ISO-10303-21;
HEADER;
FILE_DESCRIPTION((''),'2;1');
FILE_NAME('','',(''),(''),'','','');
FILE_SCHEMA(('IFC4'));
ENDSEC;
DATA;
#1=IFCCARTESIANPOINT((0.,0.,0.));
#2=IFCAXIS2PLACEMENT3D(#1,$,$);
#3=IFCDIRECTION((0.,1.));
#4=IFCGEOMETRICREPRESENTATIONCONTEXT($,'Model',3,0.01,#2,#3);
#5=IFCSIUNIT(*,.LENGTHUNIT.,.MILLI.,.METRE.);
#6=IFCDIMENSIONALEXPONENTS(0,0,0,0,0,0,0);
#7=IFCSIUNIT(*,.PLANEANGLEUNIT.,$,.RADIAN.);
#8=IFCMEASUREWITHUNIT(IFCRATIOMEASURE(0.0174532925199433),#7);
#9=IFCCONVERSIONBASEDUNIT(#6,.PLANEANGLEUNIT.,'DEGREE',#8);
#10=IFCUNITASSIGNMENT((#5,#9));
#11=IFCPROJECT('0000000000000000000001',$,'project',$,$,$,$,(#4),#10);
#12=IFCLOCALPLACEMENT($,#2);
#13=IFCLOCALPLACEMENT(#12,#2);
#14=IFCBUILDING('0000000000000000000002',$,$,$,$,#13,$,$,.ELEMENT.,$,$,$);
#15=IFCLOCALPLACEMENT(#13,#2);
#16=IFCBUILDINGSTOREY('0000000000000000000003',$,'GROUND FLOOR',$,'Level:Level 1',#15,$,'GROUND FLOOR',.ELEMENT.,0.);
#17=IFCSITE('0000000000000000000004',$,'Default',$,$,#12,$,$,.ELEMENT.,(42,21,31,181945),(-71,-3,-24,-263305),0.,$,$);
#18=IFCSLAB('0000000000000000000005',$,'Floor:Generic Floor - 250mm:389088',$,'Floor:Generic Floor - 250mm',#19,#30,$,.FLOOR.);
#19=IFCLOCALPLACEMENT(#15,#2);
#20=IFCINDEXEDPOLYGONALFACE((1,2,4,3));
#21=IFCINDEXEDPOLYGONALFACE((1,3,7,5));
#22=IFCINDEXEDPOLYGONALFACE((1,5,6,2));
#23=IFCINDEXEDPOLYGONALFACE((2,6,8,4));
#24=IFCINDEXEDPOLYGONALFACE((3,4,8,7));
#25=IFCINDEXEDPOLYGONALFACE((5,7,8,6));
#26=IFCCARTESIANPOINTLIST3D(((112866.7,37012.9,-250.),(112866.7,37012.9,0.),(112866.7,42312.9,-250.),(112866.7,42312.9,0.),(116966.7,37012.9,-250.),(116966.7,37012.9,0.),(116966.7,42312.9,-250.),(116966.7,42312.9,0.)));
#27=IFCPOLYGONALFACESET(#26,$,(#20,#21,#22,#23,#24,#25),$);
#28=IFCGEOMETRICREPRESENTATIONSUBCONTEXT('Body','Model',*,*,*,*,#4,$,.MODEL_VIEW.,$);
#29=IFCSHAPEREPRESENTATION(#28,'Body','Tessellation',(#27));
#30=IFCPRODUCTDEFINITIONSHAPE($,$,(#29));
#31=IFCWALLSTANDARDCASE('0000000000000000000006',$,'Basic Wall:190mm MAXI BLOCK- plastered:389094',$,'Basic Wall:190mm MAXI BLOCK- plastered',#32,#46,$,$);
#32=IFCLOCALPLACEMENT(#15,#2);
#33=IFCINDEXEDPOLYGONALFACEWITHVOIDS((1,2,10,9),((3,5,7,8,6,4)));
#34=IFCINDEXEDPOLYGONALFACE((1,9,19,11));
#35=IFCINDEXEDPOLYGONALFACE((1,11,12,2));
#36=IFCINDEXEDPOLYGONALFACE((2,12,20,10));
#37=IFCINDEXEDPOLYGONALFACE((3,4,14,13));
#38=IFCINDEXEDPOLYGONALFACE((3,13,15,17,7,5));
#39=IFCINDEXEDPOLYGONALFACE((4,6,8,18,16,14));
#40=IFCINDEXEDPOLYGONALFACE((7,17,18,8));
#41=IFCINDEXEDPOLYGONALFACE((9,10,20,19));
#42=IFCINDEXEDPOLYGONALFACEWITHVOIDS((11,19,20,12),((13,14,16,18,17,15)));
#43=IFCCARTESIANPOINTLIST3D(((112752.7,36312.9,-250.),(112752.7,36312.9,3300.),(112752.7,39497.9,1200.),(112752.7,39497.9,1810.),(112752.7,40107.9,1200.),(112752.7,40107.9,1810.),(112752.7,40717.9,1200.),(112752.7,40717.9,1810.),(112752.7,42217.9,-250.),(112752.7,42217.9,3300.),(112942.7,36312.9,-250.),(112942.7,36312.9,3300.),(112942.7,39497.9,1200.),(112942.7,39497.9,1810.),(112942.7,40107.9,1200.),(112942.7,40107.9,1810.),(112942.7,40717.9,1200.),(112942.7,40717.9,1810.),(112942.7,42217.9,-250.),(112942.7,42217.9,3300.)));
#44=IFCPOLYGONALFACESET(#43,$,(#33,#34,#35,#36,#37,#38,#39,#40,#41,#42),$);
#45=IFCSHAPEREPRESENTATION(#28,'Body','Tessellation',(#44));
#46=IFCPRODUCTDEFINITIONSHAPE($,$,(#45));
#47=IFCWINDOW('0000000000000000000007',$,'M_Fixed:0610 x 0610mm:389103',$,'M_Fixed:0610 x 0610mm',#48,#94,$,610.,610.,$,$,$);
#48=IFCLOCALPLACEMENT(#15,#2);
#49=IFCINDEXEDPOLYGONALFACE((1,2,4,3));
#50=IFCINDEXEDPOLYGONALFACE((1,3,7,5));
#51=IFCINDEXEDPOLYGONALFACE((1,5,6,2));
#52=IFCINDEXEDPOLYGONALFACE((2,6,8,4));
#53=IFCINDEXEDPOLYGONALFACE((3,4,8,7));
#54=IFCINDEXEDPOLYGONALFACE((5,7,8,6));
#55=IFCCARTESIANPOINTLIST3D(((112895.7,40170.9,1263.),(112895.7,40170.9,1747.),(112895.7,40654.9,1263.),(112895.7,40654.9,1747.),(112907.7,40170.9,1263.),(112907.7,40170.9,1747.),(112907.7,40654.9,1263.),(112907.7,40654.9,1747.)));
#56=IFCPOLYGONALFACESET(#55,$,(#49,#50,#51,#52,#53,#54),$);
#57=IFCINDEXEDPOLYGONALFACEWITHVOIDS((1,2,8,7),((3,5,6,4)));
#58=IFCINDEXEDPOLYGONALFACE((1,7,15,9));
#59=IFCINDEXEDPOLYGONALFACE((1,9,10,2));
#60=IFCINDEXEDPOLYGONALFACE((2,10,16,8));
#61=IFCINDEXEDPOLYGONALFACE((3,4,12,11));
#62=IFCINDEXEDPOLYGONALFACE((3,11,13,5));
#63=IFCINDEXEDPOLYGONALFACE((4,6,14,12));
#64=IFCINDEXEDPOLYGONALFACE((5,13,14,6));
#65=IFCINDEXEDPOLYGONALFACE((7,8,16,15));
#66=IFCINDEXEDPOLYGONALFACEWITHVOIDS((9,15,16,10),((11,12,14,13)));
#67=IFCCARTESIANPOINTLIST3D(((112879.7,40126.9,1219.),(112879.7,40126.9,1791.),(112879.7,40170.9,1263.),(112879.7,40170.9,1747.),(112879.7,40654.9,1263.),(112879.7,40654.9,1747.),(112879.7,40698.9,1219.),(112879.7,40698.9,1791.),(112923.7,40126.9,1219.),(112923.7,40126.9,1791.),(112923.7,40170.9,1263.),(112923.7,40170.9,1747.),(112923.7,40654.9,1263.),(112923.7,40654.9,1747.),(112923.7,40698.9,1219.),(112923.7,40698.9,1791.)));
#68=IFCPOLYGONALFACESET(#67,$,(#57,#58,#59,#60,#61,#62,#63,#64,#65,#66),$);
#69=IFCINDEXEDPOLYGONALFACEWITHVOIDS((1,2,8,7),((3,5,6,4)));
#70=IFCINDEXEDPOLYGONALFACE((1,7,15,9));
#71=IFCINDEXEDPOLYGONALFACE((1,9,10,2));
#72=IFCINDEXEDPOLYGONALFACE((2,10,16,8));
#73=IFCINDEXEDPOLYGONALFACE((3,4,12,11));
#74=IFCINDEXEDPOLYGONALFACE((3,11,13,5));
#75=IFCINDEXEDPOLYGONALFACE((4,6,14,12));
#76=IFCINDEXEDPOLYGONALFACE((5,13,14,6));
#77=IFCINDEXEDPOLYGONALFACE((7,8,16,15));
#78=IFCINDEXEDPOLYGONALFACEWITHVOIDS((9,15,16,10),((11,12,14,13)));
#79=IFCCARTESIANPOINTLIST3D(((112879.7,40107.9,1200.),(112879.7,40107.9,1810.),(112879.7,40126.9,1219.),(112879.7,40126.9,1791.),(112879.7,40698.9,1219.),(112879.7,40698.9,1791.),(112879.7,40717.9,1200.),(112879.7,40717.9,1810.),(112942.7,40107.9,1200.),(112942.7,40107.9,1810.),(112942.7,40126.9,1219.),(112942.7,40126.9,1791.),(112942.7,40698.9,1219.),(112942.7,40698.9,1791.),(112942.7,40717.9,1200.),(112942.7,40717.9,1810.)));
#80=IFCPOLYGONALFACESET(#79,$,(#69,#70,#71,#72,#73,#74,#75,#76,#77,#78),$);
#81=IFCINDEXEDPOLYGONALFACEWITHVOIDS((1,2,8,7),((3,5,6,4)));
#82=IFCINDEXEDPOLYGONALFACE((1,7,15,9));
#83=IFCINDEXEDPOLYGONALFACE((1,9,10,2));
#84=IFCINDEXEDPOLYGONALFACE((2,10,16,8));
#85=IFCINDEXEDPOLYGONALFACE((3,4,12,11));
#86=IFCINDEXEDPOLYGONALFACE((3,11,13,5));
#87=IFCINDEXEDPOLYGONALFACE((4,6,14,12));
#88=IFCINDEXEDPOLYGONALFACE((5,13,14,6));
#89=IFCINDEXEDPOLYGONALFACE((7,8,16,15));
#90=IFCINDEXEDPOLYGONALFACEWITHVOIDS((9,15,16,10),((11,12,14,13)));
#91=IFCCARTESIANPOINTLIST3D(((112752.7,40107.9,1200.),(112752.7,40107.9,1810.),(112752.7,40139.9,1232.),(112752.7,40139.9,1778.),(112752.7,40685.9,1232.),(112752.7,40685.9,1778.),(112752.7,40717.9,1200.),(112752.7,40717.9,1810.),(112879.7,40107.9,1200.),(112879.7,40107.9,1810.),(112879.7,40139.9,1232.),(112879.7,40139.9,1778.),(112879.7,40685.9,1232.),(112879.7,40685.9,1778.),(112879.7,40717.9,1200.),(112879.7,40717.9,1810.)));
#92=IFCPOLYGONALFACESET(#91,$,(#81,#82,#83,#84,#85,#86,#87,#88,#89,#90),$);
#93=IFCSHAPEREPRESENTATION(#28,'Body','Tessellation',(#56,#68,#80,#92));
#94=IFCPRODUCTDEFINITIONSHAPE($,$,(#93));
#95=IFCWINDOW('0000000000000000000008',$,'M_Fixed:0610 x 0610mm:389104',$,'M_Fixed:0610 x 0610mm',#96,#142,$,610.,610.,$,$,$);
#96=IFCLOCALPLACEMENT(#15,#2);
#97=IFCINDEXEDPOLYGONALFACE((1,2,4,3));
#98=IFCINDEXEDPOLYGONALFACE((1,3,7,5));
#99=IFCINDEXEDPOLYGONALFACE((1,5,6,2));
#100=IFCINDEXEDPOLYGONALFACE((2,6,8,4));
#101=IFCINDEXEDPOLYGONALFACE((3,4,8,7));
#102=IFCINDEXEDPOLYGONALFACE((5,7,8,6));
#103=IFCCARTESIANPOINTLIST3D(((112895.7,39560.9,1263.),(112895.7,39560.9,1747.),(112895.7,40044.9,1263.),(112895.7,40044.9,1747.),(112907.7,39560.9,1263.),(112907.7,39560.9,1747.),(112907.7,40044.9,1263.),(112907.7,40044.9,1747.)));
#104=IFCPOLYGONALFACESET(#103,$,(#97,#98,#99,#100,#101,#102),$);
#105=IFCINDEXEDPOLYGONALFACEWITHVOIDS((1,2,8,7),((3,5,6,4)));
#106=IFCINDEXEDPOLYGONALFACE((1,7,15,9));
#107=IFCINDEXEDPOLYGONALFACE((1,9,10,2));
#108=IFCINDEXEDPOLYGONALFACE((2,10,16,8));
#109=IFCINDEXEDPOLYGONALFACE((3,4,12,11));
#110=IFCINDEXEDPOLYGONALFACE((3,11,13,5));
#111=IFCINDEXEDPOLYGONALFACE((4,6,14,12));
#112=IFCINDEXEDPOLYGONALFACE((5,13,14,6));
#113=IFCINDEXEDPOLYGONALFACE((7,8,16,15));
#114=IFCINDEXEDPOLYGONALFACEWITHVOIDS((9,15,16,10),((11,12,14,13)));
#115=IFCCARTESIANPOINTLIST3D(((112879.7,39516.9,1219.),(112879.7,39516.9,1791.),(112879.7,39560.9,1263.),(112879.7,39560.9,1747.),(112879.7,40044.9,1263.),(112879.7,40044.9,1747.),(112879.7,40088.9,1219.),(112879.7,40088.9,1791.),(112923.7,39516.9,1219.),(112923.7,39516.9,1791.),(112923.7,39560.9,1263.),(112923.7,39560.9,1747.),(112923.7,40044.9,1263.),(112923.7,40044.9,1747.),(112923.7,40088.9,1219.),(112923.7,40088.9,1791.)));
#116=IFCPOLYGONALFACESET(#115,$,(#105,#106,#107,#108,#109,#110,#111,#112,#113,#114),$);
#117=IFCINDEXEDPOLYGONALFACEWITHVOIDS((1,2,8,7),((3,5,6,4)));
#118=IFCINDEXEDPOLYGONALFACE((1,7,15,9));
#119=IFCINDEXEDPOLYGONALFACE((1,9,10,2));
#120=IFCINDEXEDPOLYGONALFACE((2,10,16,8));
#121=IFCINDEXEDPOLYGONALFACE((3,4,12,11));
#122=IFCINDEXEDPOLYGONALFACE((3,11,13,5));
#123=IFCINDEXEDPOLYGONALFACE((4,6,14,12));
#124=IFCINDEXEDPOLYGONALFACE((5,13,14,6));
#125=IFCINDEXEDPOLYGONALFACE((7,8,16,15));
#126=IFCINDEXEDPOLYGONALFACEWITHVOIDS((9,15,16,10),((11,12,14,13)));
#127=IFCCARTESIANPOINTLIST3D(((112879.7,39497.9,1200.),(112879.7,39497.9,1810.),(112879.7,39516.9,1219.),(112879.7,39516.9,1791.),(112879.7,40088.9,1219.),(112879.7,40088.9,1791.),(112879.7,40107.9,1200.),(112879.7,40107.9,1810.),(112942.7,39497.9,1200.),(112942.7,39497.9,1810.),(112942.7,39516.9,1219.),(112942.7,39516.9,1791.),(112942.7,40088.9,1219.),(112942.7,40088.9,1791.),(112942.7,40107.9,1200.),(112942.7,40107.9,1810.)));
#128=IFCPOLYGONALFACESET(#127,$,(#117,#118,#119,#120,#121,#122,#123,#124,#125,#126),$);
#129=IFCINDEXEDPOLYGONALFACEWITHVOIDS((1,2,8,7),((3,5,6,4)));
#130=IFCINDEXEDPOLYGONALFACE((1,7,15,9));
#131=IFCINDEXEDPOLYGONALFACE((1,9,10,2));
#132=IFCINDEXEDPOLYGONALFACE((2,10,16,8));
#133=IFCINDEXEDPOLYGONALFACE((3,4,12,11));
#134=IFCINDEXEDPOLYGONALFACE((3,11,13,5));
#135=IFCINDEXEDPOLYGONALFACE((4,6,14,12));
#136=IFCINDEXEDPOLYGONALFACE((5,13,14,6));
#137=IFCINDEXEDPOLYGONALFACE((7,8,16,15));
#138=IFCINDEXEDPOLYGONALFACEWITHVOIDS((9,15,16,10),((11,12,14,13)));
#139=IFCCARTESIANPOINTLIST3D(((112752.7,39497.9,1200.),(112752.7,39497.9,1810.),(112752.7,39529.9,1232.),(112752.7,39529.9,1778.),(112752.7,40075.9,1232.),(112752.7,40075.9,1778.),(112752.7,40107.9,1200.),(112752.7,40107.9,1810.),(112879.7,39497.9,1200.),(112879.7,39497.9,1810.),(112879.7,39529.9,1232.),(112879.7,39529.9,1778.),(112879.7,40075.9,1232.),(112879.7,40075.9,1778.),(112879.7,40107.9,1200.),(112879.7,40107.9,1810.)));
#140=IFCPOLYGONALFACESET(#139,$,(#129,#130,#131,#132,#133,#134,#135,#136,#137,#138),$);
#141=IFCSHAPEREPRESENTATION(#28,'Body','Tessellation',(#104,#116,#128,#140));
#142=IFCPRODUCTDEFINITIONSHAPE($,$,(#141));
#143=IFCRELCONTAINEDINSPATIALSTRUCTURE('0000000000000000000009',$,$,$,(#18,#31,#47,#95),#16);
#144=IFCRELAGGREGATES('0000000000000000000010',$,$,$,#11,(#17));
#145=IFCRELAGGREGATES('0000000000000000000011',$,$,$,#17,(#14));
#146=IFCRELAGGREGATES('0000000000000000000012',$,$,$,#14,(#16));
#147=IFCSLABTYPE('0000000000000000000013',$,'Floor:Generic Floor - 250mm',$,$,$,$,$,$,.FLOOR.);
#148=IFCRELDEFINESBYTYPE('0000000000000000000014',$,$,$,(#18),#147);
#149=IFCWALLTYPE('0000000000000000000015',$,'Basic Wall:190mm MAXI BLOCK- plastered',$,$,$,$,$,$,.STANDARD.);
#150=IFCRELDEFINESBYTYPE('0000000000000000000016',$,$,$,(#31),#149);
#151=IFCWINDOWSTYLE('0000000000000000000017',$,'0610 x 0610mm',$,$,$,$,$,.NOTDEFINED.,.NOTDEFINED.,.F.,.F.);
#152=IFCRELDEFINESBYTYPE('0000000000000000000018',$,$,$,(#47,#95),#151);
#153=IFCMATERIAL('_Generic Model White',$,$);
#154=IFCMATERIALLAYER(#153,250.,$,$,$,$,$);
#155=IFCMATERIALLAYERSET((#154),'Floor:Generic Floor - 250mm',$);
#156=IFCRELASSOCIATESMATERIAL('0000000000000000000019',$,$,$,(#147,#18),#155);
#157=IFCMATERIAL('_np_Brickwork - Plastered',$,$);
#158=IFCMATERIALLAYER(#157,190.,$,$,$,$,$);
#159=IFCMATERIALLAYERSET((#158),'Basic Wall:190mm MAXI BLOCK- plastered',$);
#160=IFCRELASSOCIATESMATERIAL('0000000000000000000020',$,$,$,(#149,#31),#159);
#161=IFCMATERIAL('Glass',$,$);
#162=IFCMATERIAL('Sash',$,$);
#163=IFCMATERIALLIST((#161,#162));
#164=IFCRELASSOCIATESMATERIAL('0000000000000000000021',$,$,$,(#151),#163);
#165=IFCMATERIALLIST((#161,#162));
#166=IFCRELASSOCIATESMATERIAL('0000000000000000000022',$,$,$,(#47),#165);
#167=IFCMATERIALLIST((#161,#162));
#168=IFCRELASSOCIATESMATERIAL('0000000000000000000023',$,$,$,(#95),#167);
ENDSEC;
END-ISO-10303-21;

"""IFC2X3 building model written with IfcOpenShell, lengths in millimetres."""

from ifc_helpers import new_model, entity, si_unit, converted_unit, direction, frame, frame_2d, origin, place, context, subcontext, project, spatial, polyline, rectangle, outline, extrude, source, transform, mapped, material, material_list, layer, layer_set, layer_usage, type_object, type_shapes, element, fill, save


model = new_model("IFC2X3")

# Units and contexts
model_context = context("Model", 3, precision=0.01, world=origin(), true_north=direction((0.0, 1.0)))
body_context = subcontext(model_context, "Body", "Model", "MODEL_VIEW")
ifc_project = project(units=[si_unit("LENGTHUNIT", "METRE", prefix="MILLI"), converted_unit("PLANEANGLEUNIT", "DEGREE", entity("IfcRatioMeasure", 0.0174532925199433), si_unit("PLANEANGLEUNIT", "RADIAN"), dimensions=[0, 0, 0, 0, 0, 0, 0])], contexts=[model_context])

# Site, building, storey
site_placement = place(None, origin())
site = spatial("IfcSite", under=ifc_project, at=site_placement, Name="Default", CompositionType="ELEMENT", RefLatitude=(42, 21, 31, 181945), RefLongitude=(-71, -3, -24, -263305), RefElevation=0.0)
building_placement = place(site_placement, origin())
building = spatial("IfcBuilding", under=site, at=building_placement, CompositionType="ELEMENT")
storey_placement = place(building_placement, origin())
storey = spatial("IfcBuildingStorey", under=building, at=storey_placement, Name="GROUND FLOOR", ObjectType="Level:Level 1", LongName="GROUND FLOOR", CompositionType="ELEMENT", Elevation=0.0)

# Slab
ifc_material_1 = material(Name="_Generic Model White")
ifc_layer_1 = layer(ifc_material_1, 250.0)
ifc_layer_set_1 = layer_set([ifc_layer_1], Name="Floor:Generic Floor - 250mm")
ifc_layer_usage_1 = layer_usage(ifc_layer_set_1, "AXIS3", "POSITIVE", 0.0)
slab_type = type_object("IfcSlabType", Name="Floor:Generic Floor - 250mm", PredefinedType="FLOOR", material=ifc_layer_set_1)
slab_placement = place(storey_placement, origin())
element("IfcSlab", 1, at=slab_placement, inside=storey, type_object=slab_type, material=ifc_layer_usage_1, Name="Floor:Generic Floor - 250mm:389088", ObjectType="Floor:Generic Floor - 250mm", PredefinedType="FLOOR", context=body_context, shape_type="SweptSolid", body=[
    extrude(rectangle(XDim=5300.0, YDim=4100.0, at=frame_2d((0.0, 0.0), x_axis=(1.0, 0.0))), frame((114916.7, 39662.9, 0.0), z_axis=(0.0, 0.0, -1.0), x_axis=(0.0, 1.0, 0.0)), (0.0, 0.0, 1.0), 250.0),
])

# Wall, openings, windows
ifc_material_2 = material(Name="_np_Brickwork - Plastered")
ifc_layer_2 = layer(ifc_material_2, 190.0)
ifc_layer_set_2 = layer_set([ifc_layer_2], Name="Basic Wall:190mm MAXI BLOCK- plastered")
ifc_layer_usage_2 = layer_usage(ifc_layer_set_2, "AXIS2", "NEGATIVE", 95.0)
wall_type = type_object("IfcWallType", Name="Basic Wall:190mm MAXI BLOCK- plastered", PredefinedType="STANDARD", material=ifc_layer_set_2)
wall_placement = place(storey_placement, frame((112847.7, 36312.9, -250.0), z_axis=(0.0, 0.0, 1.0), x_axis=(0.0, 1.0, 0.0)))
wall = element("IfcWallStandardCase", 2, at=wall_placement, inside=storey, type_object=wall_type, material=ifc_layer_usage_2, Name="Basic Wall:190mm MAXI BLOCK- plastered:389094", ObjectType="Basic Wall:190mm MAXI BLOCK- plastered", context=body_context, shape_type="SweptSolid", body=[
    extrude(rectangle(XDim=5905.0, YDim=190.0, at=frame_2d((2952.5, 0.0), x_axis=(-1.0, 0.0))), origin(), (0.0, 0.0, 1.0), 3550.0),
])
opening_1_placement = place(wall_placement, frame((4405.0, 95.0, 1450.0)))
opening_1 = element("IfcOpeningElement", 3, at=opening_1_placement, cuts=wall, ObjectType="Opening", context=body_context, shape_type="SweptSolid", body=[
    extrude(rectangle(XDim=610.0, YDim=610.0, at=frame_2d((305.0, 305.0), x_axis=(1.0, 0.0))), frame((0.0, 0.0, 0.0), z_axis=(0.0, -1.0, 0.0), x_axis=(0.0, 0.0, 1.0)), (0.0, 0.0, 1.0), 190.0),
])
opening_2_placement = place(wall_placement, frame((3795.0, 95.0, 1450.0)))
opening_2 = element("IfcOpeningElement", 4, at=opening_2_placement, cuts=wall, ObjectType="Opening", context=body_context, shape_type="SweptSolid", body=[
    extrude(rectangle(XDim=610.0, YDim=610.0, at=frame_2d((305.0, 305.0), x_axis=(1.0, 0.0))), frame((0.0, 0.0, 0.0), z_axis=(0.0, -1.0, 0.0), x_axis=(0.0, 0.0, 1.0)), (0.0, 0.0, 1.0), 190.0),
])
ifc_material_3 = material(Name="Glass")
ifc_material_4 = material(Name="Sash")
ifc_material_list_1 = material_list([ifc_material_3, ifc_material_4])
ifc_material_list_2 = material_list([ifc_material_3, ifc_material_4])
window_style = type_object("IfcWindowStyle", Name="0610 x 0610mm", ConstructionType="NOTDEFINED", OperationType="NOTDEFINED", ParameterTakesPrecedence=False, Sizeable=False, material=ifc_material_list_2)
shared_shape_1 = source(origin(), body_context, "Body", "SweptSolid", [
    extrude(rectangle(XDim=12.0, YDim=484.0, at=frame_2d((0.0, 0.0), x_axis=(1.0, 0.0))), frame((305.0, 149.0, 63.0), z_axis=(0.0, 0.0, 1.0), x_axis=(0.0, -1.0, 0.0)), (0.0, 0.0, 1.0), 484.0),
    extrude(outline(polyline([(-286.0, -286.0), (286.0, -286.0), (286.0, 286.0), (-286.0, 286.0), (-286.0, -286.0)]), holes=[polyline([(-242.0, -242.0), (-242.0, 242.0), (242.0, 242.0), (242.0, -242.0), (-242.0, -242.0)])]), frame((305.0, 127.0, 305.0), z_axis=(0.0, 1.0, 0.0), x_axis=(1.0, 0.0, 0.0)), (0.0, 0.0, 1.0), 44.0),
    extrude(outline(polyline([(-305.0, -305.0), (305.0, -305.0), (305.0, 305.0), (-305.0, 305.0), (-305.0, -305.0)]), holes=[polyline([(-286.0, -286.0), (-286.0, 286.0), (286.0, 286.0), (286.0, -286.0), (-286.0, -286.0)])]), frame((305.0, 127.0, 305.0), z_axis=(0.0, 1.0, 0.0), x_axis=(1.0, 0.0, 0.0)), (0.0, 0.0, 1.0), 63.0),
    extrude(outline(polyline([(-305.0, -305.0), (305.0, -305.0), (305.0, 305.0), (-305.0, 305.0), (-305.0, -305.0)]), holes=[polyline([(-273.0, -273.0), (-273.0, 273.0), (273.0, 273.0), (273.0, -273.0), (-273.0, -273.0)])]), frame((305.0, 0.0, 305.0), z_axis=(0.0, 1.0, 0.0), x_axis=(1.0, 0.0, 0.0)), (0.0, 0.0, 1.0), 127.0),
])
type_shapes(window_style, [shared_shape_1])
window_1_placement = place(opening_1_placement, frame((0.0, 0.0, 0.0), z_axis=(0.0, 0.0, 1.0), x_axis=(-1.0, 0.0, 0.0)))
window_1 = element("IfcWindow", 5, at=window_1_placement, inside=storey, type_object=window_style, material=ifc_material_list_1, Name="M_Fixed:0610 x 0610mm:389103", ObjectType="M_Fixed:0610 x 0610mm", OverallHeight=610.0, OverallWidth=610.0, context=body_context, shape_type="MappedRepresentation", body=[
    mapped(shared_shape_1, transform((0.0, 0.0, 0.0), scale=1.0)),
])
fill(opening_1, window_1)
ifc_material_list_3 = material_list([ifc_material_3, ifc_material_4])
window_2_placement = place(opening_2_placement, frame((0.0, 0.0, 0.0), z_axis=(0.0, 0.0, 1.0), x_axis=(-1.0, 0.0, 0.0)))
window_2 = element("IfcWindow", 6, at=window_2_placement, inside=storey, type_object=window_style, material=ifc_material_list_3, Name="M_Fixed:0610 x 0610mm:389104", ObjectType="M_Fixed:0610 x 0610mm", OverallHeight=610.0, OverallWidth=610.0, context=body_context, shape_type="MappedRepresentation", body=[
    mapped(shared_shape_1, transform((0.0, 0.0, 0.0), scale=1.0)),
])
fill(opening_2, window_2)

save(model, "model.ifc")
